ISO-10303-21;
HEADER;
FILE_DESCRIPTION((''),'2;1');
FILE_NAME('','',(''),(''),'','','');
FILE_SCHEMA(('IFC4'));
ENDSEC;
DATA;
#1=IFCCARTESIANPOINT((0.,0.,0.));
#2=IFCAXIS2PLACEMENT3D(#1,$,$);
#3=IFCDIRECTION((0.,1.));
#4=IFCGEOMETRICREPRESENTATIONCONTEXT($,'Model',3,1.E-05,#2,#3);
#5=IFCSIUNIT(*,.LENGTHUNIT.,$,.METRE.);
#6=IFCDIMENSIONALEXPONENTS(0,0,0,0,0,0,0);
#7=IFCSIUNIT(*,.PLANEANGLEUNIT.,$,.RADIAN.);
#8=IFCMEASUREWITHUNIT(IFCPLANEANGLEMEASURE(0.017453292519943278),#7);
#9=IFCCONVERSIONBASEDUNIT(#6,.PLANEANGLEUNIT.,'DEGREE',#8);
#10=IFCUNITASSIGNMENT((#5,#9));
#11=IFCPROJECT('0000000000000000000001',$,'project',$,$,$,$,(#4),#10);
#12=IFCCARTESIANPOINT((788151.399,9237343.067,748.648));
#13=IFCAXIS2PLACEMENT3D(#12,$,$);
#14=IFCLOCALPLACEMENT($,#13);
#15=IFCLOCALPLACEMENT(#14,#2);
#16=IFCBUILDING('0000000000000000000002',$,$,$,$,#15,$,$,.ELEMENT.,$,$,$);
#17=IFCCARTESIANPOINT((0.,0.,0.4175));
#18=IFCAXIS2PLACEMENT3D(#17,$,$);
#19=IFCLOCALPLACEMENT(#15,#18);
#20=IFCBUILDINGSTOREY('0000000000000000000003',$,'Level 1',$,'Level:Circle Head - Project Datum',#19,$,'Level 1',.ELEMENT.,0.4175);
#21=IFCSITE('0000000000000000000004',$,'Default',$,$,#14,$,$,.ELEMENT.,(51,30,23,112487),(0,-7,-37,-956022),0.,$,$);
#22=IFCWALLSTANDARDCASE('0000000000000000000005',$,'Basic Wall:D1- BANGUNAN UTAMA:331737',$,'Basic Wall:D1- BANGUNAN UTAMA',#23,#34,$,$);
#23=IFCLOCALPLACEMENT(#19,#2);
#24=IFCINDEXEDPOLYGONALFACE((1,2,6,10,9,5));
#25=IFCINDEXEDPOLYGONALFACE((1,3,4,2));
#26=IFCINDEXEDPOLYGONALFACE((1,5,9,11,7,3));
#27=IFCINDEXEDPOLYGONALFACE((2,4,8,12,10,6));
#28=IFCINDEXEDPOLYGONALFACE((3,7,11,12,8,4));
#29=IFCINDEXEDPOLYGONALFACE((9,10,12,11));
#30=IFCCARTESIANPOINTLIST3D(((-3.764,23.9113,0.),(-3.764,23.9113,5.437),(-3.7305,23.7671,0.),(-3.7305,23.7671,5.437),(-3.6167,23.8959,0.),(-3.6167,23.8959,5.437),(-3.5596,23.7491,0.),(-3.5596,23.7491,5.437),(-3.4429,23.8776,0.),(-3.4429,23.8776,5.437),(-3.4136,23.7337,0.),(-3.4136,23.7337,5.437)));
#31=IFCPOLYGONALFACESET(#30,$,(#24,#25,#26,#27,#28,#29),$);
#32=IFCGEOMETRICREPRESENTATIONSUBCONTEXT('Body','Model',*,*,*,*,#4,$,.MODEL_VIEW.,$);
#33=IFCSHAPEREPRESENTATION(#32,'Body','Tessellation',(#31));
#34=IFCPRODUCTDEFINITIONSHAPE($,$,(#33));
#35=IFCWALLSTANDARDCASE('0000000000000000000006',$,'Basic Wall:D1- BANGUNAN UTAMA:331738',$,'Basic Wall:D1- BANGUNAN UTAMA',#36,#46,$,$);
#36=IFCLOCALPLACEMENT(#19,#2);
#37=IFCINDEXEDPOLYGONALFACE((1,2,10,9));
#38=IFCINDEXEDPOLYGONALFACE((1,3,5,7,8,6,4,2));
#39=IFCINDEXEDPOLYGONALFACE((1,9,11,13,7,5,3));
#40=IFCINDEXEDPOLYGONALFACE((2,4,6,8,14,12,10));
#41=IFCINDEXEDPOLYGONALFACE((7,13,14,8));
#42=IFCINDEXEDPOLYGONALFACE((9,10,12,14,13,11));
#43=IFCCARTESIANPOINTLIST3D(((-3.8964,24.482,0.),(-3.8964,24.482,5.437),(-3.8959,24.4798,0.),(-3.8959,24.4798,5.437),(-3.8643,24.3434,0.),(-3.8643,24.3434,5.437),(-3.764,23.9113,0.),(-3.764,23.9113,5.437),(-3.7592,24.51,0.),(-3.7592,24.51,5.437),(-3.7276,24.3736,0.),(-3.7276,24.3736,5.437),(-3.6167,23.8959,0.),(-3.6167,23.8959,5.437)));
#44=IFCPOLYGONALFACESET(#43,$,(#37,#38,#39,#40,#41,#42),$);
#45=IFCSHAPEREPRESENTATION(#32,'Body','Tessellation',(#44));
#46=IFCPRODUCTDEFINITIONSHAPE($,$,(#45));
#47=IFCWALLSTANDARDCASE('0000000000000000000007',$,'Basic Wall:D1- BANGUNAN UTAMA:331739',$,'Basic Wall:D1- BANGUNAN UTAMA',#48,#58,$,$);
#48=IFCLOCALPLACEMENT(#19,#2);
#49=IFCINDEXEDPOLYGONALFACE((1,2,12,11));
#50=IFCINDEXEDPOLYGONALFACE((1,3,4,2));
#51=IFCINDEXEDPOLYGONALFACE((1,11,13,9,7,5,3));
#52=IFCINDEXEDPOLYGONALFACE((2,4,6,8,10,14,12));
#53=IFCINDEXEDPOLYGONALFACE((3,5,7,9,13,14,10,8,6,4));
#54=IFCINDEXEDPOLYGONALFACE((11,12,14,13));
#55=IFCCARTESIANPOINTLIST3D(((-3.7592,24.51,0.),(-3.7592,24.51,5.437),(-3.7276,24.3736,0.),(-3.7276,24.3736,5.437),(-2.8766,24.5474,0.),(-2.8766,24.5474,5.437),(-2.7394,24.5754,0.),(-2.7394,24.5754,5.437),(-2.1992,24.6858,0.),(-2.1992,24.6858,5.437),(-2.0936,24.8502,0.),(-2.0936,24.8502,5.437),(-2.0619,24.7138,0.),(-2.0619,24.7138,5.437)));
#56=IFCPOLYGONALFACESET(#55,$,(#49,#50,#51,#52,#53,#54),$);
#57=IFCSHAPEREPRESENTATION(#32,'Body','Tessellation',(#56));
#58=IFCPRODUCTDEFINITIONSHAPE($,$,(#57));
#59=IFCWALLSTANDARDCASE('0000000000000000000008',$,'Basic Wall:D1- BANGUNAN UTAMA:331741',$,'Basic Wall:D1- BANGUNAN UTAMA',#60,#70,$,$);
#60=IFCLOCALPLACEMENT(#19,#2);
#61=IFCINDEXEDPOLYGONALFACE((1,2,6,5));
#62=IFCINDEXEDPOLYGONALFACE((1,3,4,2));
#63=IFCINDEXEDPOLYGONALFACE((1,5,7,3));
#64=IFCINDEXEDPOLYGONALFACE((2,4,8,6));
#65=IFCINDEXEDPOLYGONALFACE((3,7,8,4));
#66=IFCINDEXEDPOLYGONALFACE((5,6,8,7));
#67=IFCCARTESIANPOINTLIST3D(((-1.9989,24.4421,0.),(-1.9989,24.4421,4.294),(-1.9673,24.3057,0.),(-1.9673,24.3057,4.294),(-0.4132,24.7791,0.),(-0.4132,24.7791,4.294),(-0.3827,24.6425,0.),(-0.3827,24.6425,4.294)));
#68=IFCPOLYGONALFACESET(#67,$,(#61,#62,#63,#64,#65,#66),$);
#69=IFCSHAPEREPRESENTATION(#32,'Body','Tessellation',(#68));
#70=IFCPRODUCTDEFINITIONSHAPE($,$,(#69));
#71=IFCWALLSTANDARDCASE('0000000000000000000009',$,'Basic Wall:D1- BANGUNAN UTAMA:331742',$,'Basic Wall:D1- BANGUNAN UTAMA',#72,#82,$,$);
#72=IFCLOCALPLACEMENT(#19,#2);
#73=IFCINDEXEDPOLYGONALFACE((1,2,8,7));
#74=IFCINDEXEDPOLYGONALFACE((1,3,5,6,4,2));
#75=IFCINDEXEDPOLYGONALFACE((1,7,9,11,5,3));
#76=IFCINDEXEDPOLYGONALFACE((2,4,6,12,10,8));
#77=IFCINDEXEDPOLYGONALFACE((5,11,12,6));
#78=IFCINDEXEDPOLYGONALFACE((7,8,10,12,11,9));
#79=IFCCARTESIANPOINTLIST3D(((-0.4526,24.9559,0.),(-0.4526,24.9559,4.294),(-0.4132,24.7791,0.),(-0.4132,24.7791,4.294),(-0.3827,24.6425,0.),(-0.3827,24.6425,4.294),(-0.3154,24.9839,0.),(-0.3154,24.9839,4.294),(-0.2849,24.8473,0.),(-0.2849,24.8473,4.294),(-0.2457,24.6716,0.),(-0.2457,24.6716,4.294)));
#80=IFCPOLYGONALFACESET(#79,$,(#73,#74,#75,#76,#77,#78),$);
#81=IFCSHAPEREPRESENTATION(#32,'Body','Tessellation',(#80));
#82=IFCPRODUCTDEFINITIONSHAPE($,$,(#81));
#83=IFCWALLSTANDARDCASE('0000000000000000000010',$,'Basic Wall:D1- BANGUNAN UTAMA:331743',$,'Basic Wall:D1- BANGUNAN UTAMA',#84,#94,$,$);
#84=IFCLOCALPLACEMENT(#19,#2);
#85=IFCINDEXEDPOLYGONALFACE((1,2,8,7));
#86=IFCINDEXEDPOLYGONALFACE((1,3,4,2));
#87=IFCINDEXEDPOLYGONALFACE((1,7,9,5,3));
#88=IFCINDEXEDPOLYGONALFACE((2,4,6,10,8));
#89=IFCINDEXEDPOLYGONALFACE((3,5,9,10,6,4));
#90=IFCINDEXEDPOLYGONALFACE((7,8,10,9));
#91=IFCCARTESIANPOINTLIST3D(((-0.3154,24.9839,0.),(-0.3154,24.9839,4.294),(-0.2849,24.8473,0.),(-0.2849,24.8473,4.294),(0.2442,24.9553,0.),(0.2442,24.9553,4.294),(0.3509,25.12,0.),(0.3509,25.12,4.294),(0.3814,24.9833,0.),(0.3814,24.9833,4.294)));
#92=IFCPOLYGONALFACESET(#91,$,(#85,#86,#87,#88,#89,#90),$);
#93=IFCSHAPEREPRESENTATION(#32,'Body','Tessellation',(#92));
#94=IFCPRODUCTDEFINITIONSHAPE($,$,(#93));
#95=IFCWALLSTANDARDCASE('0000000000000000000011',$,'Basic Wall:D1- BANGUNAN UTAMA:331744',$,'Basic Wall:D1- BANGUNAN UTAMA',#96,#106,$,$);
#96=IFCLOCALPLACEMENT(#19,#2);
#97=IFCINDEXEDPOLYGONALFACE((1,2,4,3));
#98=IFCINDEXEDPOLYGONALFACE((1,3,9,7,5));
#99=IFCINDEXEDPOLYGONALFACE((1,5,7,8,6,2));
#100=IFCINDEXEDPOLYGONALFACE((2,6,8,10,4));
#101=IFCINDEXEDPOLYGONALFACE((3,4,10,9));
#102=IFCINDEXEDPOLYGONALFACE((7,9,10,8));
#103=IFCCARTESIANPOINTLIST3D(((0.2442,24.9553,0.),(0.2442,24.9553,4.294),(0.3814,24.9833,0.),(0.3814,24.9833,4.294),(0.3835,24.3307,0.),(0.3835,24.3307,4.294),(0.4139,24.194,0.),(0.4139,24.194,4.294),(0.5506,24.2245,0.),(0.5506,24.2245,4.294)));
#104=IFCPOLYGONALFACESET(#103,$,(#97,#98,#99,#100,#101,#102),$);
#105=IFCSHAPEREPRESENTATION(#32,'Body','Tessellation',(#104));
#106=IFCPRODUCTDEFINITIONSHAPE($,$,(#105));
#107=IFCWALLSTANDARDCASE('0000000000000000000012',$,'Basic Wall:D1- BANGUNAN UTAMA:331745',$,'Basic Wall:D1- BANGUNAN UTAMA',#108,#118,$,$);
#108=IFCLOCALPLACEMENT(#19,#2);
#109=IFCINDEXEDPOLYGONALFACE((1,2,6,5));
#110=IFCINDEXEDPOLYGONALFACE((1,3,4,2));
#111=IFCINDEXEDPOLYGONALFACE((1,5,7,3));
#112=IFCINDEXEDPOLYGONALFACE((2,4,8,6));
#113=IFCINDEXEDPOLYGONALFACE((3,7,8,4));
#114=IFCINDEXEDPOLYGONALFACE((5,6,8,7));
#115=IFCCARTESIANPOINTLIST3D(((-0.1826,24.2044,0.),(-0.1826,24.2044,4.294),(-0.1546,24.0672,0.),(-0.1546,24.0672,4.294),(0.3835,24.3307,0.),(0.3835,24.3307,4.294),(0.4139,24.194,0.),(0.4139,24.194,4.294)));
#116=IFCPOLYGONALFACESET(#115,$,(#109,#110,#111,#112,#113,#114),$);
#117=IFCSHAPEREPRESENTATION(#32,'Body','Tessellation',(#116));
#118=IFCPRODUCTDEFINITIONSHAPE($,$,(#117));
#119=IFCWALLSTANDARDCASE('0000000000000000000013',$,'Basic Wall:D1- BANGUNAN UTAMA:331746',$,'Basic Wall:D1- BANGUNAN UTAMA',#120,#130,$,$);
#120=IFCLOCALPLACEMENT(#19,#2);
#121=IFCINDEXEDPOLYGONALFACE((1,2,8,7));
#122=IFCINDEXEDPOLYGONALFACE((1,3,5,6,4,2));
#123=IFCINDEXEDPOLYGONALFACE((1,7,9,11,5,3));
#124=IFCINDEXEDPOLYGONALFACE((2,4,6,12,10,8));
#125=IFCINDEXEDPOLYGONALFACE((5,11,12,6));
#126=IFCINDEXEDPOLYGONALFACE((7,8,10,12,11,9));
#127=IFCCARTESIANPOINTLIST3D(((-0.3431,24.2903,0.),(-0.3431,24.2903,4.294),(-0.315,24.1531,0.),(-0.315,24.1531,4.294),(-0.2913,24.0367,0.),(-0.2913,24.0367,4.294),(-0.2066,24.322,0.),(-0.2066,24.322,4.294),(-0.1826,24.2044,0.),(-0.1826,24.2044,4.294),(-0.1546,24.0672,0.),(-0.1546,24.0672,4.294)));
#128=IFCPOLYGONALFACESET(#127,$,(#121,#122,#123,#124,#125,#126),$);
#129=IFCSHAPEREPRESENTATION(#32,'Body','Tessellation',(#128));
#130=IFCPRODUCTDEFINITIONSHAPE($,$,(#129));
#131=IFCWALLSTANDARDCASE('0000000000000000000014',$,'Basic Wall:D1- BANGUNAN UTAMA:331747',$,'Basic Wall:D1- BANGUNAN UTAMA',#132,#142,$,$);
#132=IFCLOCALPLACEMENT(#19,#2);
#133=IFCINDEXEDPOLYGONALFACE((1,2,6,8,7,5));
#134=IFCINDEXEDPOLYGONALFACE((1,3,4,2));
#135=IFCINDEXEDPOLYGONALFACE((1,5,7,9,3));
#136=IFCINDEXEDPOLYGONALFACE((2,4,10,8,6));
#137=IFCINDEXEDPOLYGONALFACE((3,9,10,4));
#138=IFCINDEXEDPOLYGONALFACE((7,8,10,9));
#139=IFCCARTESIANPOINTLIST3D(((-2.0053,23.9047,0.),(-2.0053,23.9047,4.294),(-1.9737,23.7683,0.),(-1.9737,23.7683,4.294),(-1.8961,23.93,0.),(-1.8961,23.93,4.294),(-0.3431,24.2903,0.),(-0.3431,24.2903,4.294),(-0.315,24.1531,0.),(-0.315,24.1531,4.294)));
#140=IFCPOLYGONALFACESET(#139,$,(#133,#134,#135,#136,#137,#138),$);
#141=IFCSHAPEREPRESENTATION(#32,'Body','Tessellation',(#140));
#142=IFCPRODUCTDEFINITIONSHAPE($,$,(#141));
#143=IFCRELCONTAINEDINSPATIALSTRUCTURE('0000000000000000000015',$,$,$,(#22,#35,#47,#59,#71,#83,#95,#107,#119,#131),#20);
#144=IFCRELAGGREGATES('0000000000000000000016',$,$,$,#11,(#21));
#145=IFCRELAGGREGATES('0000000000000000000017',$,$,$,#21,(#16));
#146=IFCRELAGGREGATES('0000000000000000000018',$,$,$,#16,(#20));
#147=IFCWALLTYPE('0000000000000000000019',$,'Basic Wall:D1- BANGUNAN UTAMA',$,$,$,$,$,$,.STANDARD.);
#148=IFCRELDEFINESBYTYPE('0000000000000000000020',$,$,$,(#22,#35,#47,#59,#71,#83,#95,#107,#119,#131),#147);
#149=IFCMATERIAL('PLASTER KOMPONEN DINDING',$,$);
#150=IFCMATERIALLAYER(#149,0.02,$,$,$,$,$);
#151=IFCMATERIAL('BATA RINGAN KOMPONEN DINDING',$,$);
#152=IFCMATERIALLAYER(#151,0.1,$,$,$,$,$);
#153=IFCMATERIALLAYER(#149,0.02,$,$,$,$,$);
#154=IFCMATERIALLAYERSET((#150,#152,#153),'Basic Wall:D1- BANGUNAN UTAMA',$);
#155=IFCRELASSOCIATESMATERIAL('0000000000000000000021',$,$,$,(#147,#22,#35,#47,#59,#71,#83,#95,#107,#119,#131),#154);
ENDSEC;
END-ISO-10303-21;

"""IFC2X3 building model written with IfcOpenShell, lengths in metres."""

from ifc_helpers import new_model, entity, si_unit, converted_unit, direction, frame, origin, place, context, subcontext, project, spatial, polyline, outline, extrude, material, layer, layer_set, layer_usage, type_object, element, save


model = new_model("IFC2X3")

# Units and contexts
model_context = context("Model", 3, precision=1e-05, world=origin(), true_north=direction((0.0, 1.0)))
body_context = subcontext(model_context, "Body", "Model", "MODEL_VIEW")
ifc_project = project(units=[si_unit("LENGTHUNIT", "METRE"), converted_unit("PLANEANGLEUNIT", "DEGREE", entity("IfcPlaneAngleMeasure", 0.017453292519943278), si_unit("PLANEANGLEUNIT", "RADIAN"), dimensions=[0, 0, 0, 0, 0, 0, 0])], contexts=[model_context])

# Site, building, storey
site_placement = place(None, frame((788151.399, 9237343.067, 748.648)))
site = spatial("IfcSite", under=ifc_project, at=site_placement, Name="Default", CompositionType="ELEMENT", RefLatitude=(51, 30, 23, 112487), RefLongitude=(0, -7, -37, -956022), RefElevation=0.0)
building_placement = place(site_placement, origin())
building = spatial("IfcBuilding", under=site, at=building_placement, CompositionType="ELEMENT")
storey_placement = place(building_placement, frame((0.0, 0.0, 0.4175)))
storey = spatial("IfcBuildingStorey", under=building, at=storey_placement, Name="Level 1", ObjectType="Level:Circle Head - Project Datum", LongName="Level 1", CompositionType="ELEMENT", Elevation=0.4175)

# Walls
ifc_material_1 = material(Name="PLASTER KOMPONEN DINDING")
ifc_layer_1 = layer(ifc_material_1, 0.02)
ifc_material_2 = material(Name="BATA RINGAN KOMPONEN DINDING")
ifc_layer_2 = layer(ifc_material_2, 0.1)
ifc_layer_3 = layer(ifc_material_1, 0.02)
ifc_layer_set_1 = layer_set([ifc_layer_1, ifc_layer_2, ifc_layer_3], Name="Basic Wall:D1- BANGUNAN UTAMA")
wall_type_1 = type_object("IfcWallType", Name="Basic Wall:D1- BANGUNAN UTAMA", PredefinedType="STANDARD", material=ifc_layer_set_1)
ifc_layer_usage_1 = layer_usage(ifc_layer_set_1, "AXIS2", "POSITIVE", -0.07)
wall_1_placement = place(storey_placement, frame((-3.4063, 23.8033, 0.0), z_axis=(0.0, 0.0, 1.0), x_axis=(-0.994511, 0.104628, 0.0)))
element("IfcWallStandardCase", 1, at=wall_1_placement, inside=storey, type_object=wall_type_1, material=ifc_layer_usage_1, Name="Basic Wall:D1- BANGUNAN UTAMA:331737", ObjectType="Basic Wall:D1- BANGUNAN UTAMA", context=body_context, shape_type="SweptSolid", body=[
    extrude(outline(polyline([(0.3671, -0.07), (0.3187, 0.07), (0.1468, 0.07), (0.0, 0.07), (0.0442, -0.07), (0.2189, -0.07), (0.3671, -0.07)])), origin(), (0.0, 0.0, 1.0), 5.437),
])
ifc_layer_usage_2 = layer_usage(ifc_layer_set_1, "AXIS2", "POSITIVE", -0.07)
wall_2_placement = place(storey_placement, frame((-3.6849, 23.88, 0.0), z_axis=(0.0, 0.0, 1.0), x_axis=(-0.226012, 0.974124, 0.0)))
element("IfcWallStandardCase", 2, at=wall_2_placement, inside=storey, type_object=wall_type_1, material=ifc_layer_usage_2, Name="Basic Wall:D1- BANGUNAN UTAMA:331738", ObjectType="Basic Wall:D1- BANGUNAN UTAMA", context=body_context, shape_type="SweptSolid", body=[
    extrude(outline(polyline([(0.6305, -0.07), (0.6342, 0.07), (0.632, 0.07), (0.492, 0.07), (0.0484, 0.07), (0.0, -0.07), (0.4905, -0.07), (0.6305, -0.07)])), origin(), (0.0, 0.0, 1.0), 5.437),
])
ifc_layer_usage_3 = layer_usage(ifc_layer_set_1, "AXIS2", "POSITIVE", -0.07)
wall_3_placement = place(storey_placement, frame((-3.7452, 24.4415, 0.0), z_axis=(0.0, 0.0, 1.0), x_axis=(0.979774, 0.200109, 0.0)))
element("IfcWallStandardCase", 3, at=wall_3_placement, inside=storey, type_object=wall_type_1, material=ifc_layer_usage_3, Name="Basic Wall:D1- BANGUNAN UTAMA:331739", ObjectType="Basic Wall:D1- BANGUNAN UTAMA", context=body_context, shape_type="SweptSolid", body=[
    extrude(outline(polyline([(1.7037, -0.07), (1.7, 0.07), (0.0, 0.07), (0.0037, -0.07), (0.8722, -0.07), (1.0122, -0.07), (1.5637, -0.07), (1.7037, -0.07)])), origin(), (0.0, 0.0, 1.0), 5.437),
])
ifc_layer_usage_4 = layer_usage(ifc_layer_set_1, "AXIS2", "POSITIVE", -0.07)
wall_4_placement = place(storey_placement, frame((-1.9844, 24.3737, 0.0), z_axis=(0.0, 0.0, 1.0), x_axis=(0.978158, 0.207863, 0.0)))
element("IfcWallStandardCase", 4, at=wall_4_placement, inside=storey, type_object=wall_type_1, material=ifc_layer_usage_4, Name="Basic Wall:D1- BANGUNAN UTAMA:331741", ObjectType="Basic Wall:D1- BANGUNAN UTAMA", context=body_context, shape_type="SweptSolid", body=[
    extrude(outline(polyline([(1.6226, -0.07), (1.6212, 0.07), (0.0, 0.07), (0.0026, -0.07), (1.6226, -0.07)])), origin(), (0.0, 0.0, 1.0), 4.294),
])
ifc_layer_usage_5 = layer_usage(ifc_layer_set_1, "AXIS2", "POSITIVE", -0.07)
wall_5_placement = place(storey_placement, frame((-0.3141, 24.6563, 0.0), z_axis=(0.0, 0.0, 1.0), x_axis=(-0.217676, 0.976021, 0.0)))
element("IfcWallStandardCase", 5, at=wall_5_placement, inside=storey, type_object=wall_type_1, material=ifc_layer_usage_5, Name="Basic Wall:D1- BANGUNAN UTAMA:331742", ObjectType="Basic Wall:D1- BANGUNAN UTAMA", context=body_context, shape_type="SweptSolid", body=[
    extrude(outline(polyline([(0.32, -0.07), (0.3225, 0.07), (0.1414, 0.07), (0.0014, 0.07), (0.0, -0.07), (0.18, -0.07), (0.32, -0.07)])), origin(), (0.0, 0.0, 1.0), 4.294),
])
ifc_layer_usage_6 = layer_usage(ifc_layer_set_1, "AXIS2", "POSITIVE", -0.07)
wall_6_placement = place(storey_placement, frame((-0.3014, 24.9153, 0.0), z_axis=(0.0, 0.0, 1.0), x_axis=(0.979774, 0.200109, 0.0)))
element("IfcWallStandardCase", 6, at=wall_6_placement, inside=storey, type_object=wall_type_1, material=ifc_layer_usage_6, Name="Basic Wall:D1- BANGUNAN UTAMA:331743", ObjectType="Basic Wall:D1- BANGUNAN UTAMA", context=body_context, shape_type="SweptSolid", body=[
    extrude(outline(polyline([(0.6825, -0.07), (0.68, 0.07), (0.0, 0.07), (0.0025, -0.07), (0.5425, -0.07), (0.6825, -0.07)])), origin(), (0.0, 0.0, 1.0), 4.294),
])
ifc_layer_usage_7 = layer_usage(ifc_layer_set_1, "AXIS2", "POSITIVE", -0.07)
wall_7_placement = place(storey_placement, frame((0.3125, 24.9706, 0.0), z_axis=(0.0, 0.0, 1.0), x_axis=(0.217676, -0.976021, 0.0)))
element("IfcWallStandardCase", 7, at=wall_7_placement, inside=storey, type_object=wall_type_1, material=ifc_layer_usage_7, Name="Basic Wall:D1- BANGUNAN UTAMA:331744", ObjectType="Basic Wall:D1- BANGUNAN UTAMA", context=body_context, shape_type="SweptSolid", body=[
    extrude(outline(polyline([(0.78, -0.07), (0.78, 0.07), (0.0025, 0.07), (0.0, -0.07), (0.64, -0.07), (0.78, -0.07)])), origin(), (0.0, 0.0, 1.0), 4.294),
])
ifc_layer_usage_8 = layer_usage(ifc_layer_set_1, "AXIS2", "POSITIVE", -0.07)
wall_8_placement = place(storey_placement, frame((0.3987, 24.2623, 0.0), z_axis=(0.0, 0.0, 1.0), x_axis=(-0.976021, -0.217676, 0.0)))
element("IfcWallStandardCase", 8, at=wall_8_placement, inside=storey, type_object=wall_type_1, material=ifc_layer_usage_8, Name="Basic Wall:D1- BANGUNAN UTAMA:331745", ObjectType="Basic Wall:D1- BANGUNAN UTAMA", context=body_context, shape_type="SweptSolid", body=[
    extrude(outline(polyline([(0.58, -0.07), (0.5825, 0.07), (0.0, 0.07), (0.0, -0.07), (0.58, -0.07)])), origin(), (0.0, 0.0, 1.0), 4.294),
])
ifc_layer_usage_9 = layer_usage(ifc_layer_set_1, "AXIS2", "POSITIVE", -0.07)
wall_9_placement = place(storey_placement, frame((-0.2227, 24.0508, 0.0), z_axis=(0.0, 0.0, 1.0), x_axis=(-0.200109, 0.979774, 0.0)))
element("IfcWallStandardCase", 9, at=wall_9_placement, inside=storey, type_object=wall_type_1, material=ifc_layer_usage_9, Name="Basic Wall:D1- BANGUNAN UTAMA:331746", ObjectType="Basic Wall:D1- BANGUNAN UTAMA", context=body_context, shape_type="SweptSolid", body=[
    extrude(outline(polyline([(0.2625, -0.07), (0.2588, 0.07), (0.1188, 0.07), (0.0, 0.07), (0.0025, -0.07), (0.1425, -0.07), (0.2625, -0.07)])), origin(), (0.0, 0.0, 1.0), 4.294),
])
ifc_layer_usage_10 = layer_usage(ifc_layer_set_1, "AXIS2", "POSITIVE", -0.07)
wall_10_placement = place(storey_placement, frame((-0.3272, 24.2221, 0.0), z_axis=(0.0, 0.0, 1.0), x_axis=(-0.974124, -0.226012, 0.0)))
element("IfcWallStandardCase", 10, at=wall_10_placement, inside=storey, type_object=wall_type_1, material=ifc_layer_usage_10, Name="Basic Wall:D1- BANGUNAN UTAMA:331747", ObjectType="Basic Wall:D1- BANGUNAN UTAMA", context=body_context, shape_type="SweptSolid", body=[
    extrude(outline(polyline([(1.7064, -0.07), (1.7064, 0.07), (0.0037, 0.07), (0.0, -0.07), (1.5943, -0.07), (1.7064, -0.07)])), origin(), (0.0, 0.0, 1.0), 4.294),
])

save(model, "model.ifc")
